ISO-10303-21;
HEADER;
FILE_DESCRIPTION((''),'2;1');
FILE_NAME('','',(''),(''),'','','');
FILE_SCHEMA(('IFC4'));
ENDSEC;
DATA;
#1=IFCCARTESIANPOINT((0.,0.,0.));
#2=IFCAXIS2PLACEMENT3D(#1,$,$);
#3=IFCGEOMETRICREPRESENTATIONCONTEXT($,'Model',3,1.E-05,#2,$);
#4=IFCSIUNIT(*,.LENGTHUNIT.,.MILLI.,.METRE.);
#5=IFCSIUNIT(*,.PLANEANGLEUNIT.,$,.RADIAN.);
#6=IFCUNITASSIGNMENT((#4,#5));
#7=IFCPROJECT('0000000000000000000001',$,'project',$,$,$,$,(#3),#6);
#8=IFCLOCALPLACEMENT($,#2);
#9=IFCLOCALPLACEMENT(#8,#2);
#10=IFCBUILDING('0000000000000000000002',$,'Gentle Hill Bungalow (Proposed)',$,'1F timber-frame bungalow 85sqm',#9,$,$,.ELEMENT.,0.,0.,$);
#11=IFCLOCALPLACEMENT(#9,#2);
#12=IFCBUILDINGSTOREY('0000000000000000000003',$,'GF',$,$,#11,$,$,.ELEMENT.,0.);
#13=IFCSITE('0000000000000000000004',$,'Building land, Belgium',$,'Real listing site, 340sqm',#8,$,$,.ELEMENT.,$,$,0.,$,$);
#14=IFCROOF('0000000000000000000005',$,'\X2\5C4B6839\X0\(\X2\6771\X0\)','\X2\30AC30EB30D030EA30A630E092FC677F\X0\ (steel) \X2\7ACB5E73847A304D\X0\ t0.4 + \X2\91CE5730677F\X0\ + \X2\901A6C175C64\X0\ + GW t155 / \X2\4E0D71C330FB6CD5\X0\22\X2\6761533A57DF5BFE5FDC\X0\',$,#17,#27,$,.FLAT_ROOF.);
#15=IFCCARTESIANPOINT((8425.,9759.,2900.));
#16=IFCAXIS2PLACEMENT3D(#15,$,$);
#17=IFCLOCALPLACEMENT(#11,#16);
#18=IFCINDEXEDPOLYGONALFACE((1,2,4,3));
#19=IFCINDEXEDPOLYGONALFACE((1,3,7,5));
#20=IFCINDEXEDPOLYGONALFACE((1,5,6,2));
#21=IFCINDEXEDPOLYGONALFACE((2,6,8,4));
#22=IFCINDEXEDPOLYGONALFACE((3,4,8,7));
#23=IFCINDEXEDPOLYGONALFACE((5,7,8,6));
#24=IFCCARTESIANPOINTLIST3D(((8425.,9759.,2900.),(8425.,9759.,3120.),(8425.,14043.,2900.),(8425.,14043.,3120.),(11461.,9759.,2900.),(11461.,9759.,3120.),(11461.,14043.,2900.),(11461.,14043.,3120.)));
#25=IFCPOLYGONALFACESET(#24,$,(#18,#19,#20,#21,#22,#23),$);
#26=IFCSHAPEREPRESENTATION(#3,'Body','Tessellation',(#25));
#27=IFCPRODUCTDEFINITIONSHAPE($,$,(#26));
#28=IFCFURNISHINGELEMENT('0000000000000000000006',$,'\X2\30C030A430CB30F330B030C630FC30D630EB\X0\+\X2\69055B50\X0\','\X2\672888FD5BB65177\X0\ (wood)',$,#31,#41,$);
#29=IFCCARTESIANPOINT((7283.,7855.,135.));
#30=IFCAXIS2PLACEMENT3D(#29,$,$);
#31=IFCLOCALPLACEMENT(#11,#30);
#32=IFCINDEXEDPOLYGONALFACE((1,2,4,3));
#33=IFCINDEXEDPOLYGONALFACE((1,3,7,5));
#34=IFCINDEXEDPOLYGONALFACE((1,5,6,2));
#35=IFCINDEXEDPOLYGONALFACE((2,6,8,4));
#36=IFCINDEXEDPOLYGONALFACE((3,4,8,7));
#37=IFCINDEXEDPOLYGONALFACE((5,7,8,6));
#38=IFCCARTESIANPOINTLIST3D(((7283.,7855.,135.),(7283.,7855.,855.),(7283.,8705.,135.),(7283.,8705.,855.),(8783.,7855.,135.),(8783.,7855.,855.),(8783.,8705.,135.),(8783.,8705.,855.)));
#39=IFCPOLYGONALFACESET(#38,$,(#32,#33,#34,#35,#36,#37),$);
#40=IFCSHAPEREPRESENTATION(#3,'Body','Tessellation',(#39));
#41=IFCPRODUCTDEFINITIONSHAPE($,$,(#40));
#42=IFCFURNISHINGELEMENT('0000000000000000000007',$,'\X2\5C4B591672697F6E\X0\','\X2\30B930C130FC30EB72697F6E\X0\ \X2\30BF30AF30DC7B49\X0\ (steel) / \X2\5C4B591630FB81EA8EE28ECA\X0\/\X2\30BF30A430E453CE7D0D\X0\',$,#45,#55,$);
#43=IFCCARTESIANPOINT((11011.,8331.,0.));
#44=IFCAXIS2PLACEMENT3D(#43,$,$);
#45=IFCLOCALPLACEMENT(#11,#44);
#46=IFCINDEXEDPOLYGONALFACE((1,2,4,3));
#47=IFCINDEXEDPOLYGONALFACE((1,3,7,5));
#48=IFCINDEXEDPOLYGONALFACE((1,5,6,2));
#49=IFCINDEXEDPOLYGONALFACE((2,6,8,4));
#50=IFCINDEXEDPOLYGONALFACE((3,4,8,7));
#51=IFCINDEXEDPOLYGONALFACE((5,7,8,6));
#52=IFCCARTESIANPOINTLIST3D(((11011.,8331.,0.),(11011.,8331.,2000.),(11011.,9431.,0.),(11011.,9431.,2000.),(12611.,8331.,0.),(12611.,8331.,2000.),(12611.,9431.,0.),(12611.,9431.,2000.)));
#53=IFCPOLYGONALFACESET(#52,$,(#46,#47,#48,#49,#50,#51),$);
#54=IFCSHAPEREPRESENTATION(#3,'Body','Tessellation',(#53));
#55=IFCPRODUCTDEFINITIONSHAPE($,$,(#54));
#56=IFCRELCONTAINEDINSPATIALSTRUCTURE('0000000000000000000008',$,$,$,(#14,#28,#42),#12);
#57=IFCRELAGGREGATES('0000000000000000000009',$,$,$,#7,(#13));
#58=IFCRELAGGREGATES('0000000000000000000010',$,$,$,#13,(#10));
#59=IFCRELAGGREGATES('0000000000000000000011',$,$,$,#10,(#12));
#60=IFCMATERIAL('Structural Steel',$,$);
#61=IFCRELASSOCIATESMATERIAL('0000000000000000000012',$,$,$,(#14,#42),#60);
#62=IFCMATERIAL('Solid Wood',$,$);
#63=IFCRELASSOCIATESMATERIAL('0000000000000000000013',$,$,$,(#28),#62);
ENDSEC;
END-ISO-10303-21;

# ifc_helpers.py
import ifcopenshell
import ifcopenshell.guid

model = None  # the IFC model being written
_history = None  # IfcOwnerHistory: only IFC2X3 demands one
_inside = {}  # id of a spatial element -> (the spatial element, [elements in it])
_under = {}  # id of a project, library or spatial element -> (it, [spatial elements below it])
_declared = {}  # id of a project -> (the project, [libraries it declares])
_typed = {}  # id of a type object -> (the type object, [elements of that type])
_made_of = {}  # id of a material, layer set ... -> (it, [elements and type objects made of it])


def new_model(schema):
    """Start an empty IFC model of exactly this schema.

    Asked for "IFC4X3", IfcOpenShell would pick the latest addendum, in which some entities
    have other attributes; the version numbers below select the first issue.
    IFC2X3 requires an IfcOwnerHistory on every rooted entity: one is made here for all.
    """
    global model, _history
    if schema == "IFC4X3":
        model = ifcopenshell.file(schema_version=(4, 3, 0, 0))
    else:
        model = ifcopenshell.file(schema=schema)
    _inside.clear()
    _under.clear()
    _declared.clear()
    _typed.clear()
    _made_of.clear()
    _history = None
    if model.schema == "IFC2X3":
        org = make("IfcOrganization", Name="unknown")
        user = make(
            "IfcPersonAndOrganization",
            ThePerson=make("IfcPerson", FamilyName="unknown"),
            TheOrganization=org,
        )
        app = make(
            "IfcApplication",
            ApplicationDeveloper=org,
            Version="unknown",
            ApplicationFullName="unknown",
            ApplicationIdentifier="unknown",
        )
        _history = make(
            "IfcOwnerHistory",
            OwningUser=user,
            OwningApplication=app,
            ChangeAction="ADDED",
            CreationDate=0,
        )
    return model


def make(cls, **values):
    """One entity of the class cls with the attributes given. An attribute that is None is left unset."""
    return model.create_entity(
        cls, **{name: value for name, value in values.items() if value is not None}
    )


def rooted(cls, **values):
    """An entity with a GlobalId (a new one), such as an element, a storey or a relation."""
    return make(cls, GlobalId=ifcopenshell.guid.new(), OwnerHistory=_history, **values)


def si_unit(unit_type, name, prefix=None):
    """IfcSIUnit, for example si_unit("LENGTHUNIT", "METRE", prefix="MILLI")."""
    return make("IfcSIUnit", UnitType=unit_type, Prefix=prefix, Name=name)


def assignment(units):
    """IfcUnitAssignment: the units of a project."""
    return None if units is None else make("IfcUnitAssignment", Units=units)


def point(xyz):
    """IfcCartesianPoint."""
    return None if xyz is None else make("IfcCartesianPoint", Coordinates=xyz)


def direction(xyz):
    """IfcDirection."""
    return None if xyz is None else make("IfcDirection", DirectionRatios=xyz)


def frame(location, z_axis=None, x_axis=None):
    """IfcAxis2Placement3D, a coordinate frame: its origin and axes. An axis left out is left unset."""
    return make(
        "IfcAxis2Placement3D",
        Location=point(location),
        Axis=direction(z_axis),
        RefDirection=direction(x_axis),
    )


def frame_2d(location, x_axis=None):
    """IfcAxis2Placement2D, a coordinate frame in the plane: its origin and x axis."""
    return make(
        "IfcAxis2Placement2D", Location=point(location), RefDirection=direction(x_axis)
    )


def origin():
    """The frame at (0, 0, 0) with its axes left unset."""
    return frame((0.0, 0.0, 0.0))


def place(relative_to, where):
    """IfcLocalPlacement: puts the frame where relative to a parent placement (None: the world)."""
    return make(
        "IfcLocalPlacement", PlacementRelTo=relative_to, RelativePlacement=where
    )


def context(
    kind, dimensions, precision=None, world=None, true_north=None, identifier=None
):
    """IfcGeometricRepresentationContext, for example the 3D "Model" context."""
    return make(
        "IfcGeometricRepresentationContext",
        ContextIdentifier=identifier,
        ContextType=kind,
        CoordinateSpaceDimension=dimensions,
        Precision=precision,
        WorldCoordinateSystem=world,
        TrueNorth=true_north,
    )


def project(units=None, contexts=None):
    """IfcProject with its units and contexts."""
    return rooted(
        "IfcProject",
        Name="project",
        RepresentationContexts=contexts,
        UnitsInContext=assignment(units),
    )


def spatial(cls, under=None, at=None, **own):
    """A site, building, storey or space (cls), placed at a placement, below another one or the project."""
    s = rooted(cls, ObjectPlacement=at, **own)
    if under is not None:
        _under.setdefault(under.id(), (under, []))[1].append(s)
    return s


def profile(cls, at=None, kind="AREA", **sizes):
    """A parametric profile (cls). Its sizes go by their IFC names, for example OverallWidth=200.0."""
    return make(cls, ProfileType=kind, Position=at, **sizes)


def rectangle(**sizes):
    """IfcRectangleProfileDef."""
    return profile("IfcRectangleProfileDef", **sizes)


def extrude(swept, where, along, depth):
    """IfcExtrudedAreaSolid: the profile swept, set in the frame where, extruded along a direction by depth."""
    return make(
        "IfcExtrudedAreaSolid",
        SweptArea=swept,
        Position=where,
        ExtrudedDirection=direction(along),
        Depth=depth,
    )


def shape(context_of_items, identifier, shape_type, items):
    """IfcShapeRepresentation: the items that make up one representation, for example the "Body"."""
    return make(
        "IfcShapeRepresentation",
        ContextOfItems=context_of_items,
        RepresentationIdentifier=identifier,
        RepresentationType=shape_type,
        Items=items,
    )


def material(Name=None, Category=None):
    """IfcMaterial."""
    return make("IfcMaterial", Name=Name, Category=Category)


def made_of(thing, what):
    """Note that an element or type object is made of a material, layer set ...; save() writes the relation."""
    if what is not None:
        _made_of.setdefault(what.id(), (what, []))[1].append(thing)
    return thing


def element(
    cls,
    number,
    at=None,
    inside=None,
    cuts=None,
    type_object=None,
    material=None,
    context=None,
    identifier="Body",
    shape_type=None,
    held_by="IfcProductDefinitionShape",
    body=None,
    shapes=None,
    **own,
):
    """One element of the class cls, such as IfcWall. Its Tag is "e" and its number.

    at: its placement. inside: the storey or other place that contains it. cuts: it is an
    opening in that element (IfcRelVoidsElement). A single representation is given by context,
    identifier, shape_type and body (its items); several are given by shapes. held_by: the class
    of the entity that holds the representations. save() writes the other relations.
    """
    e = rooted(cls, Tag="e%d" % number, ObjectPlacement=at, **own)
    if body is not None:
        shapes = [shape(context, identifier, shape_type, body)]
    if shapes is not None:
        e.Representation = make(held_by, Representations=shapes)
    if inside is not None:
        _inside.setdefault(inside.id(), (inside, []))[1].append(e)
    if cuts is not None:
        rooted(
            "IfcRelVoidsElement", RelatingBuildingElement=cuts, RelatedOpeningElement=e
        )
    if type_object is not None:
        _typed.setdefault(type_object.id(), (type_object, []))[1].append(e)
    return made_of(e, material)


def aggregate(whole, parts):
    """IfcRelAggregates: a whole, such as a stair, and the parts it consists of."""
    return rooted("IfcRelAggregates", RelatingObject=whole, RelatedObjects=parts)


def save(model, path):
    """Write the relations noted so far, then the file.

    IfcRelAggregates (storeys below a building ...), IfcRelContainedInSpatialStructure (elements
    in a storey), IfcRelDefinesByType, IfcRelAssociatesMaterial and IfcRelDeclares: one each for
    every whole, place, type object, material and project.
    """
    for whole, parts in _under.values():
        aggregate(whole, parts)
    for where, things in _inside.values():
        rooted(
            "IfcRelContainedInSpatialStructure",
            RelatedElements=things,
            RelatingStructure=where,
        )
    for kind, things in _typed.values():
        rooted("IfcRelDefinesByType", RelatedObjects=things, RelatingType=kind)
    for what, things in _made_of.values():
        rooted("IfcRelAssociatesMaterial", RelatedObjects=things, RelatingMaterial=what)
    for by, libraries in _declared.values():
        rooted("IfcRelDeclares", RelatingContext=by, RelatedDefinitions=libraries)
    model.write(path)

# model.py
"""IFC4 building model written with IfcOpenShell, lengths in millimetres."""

from ifc_helpers import new_model, si_unit, frame, frame_2d, origin, place, context, project, spatial, rectangle, extrude, material, element, save


model = new_model("IFC4")

# Units and contexts
model_context = context("Model", 3, precision=1e-05, world=origin())
ifc_project = project(units=[si_unit("LENGTHUNIT", "METRE", prefix="MILLI"), si_unit("PLANEANGLEUNIT", "RADIAN")], contexts=[model_context])

# Site, building, storey
site_placement = place(None, origin())
site = spatial("IfcSite", under=ifc_project, at=site_placement, Name="Building land, Belgium", ObjectType="Real listing site, 340sqm", CompositionType="ELEMENT", RefElevation=0.0)
building_placement = place(site_placement, origin())
building = spatial("IfcBuilding", under=site, at=building_placement, Name="Gentle Hill Bungalow (Proposed)", ObjectType="1F timber-frame bungalow 85sqm", CompositionType="ELEMENT", ElevationOfRefHeight=0.0, ElevationOfTerrain=0.0)
storey_placement = place(building_placement, origin())
storey = spatial("IfcBuildingStorey", under=building, at=storey_placement, Name="GF", CompositionType="ELEMENT", Elevation=0.0)

# Shared definitions
ifc_material_1 = material(Name="Solid Wood")

# Roof
ifc_material_2 = material(Name="Structural Steel")
roof_1_placement = place(storey_placement, frame((8425.0, 9759.0, 2900.0)))
element("IfcRoof", 1, at=roof_1_placement, inside=storey, material=ifc_material_2, Name="屋根(東)", Description="ガルバリウム鋼板 (steel) 立平葺き t0.4 + 野地板 + 通気層 + GW t155 / 不燃・法22条区域対応", PredefinedType="FLAT_ROOF", context=model_context, shape_type="SweptSolid", body=[
    extrude(rectangle(XDim=3036.0, YDim=4284.0, at=frame_2d((1518.0, 2142.0))), frame((8425.0, 9759.0, 2900.0)), (0.0, 0.0, 1.0), 220.0),
])

# Furnishing elements
furnishing_1_placement = place(storey_placement, frame((7283.0, 7855.0, 135.0)))
element("IfcFurnishingElement", 2, at=furnishing_1_placement, inside=storey, material=ifc_material_1, Name="ダイニングテーブル+椅子", Description="木製家具 (wood)", context=model_context, shape_type="SweptSolid", body=[
    extrude(rectangle(XDim=1500.0, YDim=850.0, at=frame_2d((750.0, 425.0))), frame((7283.0, 7855.0, 135.0)), (0.0, 0.0, 1.0), 720.0),
])
furnishing_2_placement = place(storey_placement, frame((11011.0, 8331.0, 0.0)))
element("IfcFurnishingElement", 3, at=furnishing_2_placement, inside=storey, material=ifc_material_2, Name="屋外物置", Description="スチール物置 タクボ等 (steel) / 屋外・自転車/タイヤ収納", context=model_context, shape_type="SweptSolid", body=[
    extrude(rectangle(XDim=1600.0, YDim=1100.0, at=frame_2d((800.0, 550.0))), frame((11011.0, 8331.0, 0.0)), (0.0, 0.0, 1.0), 2000.0),
])

save(model, "model.ifc")
